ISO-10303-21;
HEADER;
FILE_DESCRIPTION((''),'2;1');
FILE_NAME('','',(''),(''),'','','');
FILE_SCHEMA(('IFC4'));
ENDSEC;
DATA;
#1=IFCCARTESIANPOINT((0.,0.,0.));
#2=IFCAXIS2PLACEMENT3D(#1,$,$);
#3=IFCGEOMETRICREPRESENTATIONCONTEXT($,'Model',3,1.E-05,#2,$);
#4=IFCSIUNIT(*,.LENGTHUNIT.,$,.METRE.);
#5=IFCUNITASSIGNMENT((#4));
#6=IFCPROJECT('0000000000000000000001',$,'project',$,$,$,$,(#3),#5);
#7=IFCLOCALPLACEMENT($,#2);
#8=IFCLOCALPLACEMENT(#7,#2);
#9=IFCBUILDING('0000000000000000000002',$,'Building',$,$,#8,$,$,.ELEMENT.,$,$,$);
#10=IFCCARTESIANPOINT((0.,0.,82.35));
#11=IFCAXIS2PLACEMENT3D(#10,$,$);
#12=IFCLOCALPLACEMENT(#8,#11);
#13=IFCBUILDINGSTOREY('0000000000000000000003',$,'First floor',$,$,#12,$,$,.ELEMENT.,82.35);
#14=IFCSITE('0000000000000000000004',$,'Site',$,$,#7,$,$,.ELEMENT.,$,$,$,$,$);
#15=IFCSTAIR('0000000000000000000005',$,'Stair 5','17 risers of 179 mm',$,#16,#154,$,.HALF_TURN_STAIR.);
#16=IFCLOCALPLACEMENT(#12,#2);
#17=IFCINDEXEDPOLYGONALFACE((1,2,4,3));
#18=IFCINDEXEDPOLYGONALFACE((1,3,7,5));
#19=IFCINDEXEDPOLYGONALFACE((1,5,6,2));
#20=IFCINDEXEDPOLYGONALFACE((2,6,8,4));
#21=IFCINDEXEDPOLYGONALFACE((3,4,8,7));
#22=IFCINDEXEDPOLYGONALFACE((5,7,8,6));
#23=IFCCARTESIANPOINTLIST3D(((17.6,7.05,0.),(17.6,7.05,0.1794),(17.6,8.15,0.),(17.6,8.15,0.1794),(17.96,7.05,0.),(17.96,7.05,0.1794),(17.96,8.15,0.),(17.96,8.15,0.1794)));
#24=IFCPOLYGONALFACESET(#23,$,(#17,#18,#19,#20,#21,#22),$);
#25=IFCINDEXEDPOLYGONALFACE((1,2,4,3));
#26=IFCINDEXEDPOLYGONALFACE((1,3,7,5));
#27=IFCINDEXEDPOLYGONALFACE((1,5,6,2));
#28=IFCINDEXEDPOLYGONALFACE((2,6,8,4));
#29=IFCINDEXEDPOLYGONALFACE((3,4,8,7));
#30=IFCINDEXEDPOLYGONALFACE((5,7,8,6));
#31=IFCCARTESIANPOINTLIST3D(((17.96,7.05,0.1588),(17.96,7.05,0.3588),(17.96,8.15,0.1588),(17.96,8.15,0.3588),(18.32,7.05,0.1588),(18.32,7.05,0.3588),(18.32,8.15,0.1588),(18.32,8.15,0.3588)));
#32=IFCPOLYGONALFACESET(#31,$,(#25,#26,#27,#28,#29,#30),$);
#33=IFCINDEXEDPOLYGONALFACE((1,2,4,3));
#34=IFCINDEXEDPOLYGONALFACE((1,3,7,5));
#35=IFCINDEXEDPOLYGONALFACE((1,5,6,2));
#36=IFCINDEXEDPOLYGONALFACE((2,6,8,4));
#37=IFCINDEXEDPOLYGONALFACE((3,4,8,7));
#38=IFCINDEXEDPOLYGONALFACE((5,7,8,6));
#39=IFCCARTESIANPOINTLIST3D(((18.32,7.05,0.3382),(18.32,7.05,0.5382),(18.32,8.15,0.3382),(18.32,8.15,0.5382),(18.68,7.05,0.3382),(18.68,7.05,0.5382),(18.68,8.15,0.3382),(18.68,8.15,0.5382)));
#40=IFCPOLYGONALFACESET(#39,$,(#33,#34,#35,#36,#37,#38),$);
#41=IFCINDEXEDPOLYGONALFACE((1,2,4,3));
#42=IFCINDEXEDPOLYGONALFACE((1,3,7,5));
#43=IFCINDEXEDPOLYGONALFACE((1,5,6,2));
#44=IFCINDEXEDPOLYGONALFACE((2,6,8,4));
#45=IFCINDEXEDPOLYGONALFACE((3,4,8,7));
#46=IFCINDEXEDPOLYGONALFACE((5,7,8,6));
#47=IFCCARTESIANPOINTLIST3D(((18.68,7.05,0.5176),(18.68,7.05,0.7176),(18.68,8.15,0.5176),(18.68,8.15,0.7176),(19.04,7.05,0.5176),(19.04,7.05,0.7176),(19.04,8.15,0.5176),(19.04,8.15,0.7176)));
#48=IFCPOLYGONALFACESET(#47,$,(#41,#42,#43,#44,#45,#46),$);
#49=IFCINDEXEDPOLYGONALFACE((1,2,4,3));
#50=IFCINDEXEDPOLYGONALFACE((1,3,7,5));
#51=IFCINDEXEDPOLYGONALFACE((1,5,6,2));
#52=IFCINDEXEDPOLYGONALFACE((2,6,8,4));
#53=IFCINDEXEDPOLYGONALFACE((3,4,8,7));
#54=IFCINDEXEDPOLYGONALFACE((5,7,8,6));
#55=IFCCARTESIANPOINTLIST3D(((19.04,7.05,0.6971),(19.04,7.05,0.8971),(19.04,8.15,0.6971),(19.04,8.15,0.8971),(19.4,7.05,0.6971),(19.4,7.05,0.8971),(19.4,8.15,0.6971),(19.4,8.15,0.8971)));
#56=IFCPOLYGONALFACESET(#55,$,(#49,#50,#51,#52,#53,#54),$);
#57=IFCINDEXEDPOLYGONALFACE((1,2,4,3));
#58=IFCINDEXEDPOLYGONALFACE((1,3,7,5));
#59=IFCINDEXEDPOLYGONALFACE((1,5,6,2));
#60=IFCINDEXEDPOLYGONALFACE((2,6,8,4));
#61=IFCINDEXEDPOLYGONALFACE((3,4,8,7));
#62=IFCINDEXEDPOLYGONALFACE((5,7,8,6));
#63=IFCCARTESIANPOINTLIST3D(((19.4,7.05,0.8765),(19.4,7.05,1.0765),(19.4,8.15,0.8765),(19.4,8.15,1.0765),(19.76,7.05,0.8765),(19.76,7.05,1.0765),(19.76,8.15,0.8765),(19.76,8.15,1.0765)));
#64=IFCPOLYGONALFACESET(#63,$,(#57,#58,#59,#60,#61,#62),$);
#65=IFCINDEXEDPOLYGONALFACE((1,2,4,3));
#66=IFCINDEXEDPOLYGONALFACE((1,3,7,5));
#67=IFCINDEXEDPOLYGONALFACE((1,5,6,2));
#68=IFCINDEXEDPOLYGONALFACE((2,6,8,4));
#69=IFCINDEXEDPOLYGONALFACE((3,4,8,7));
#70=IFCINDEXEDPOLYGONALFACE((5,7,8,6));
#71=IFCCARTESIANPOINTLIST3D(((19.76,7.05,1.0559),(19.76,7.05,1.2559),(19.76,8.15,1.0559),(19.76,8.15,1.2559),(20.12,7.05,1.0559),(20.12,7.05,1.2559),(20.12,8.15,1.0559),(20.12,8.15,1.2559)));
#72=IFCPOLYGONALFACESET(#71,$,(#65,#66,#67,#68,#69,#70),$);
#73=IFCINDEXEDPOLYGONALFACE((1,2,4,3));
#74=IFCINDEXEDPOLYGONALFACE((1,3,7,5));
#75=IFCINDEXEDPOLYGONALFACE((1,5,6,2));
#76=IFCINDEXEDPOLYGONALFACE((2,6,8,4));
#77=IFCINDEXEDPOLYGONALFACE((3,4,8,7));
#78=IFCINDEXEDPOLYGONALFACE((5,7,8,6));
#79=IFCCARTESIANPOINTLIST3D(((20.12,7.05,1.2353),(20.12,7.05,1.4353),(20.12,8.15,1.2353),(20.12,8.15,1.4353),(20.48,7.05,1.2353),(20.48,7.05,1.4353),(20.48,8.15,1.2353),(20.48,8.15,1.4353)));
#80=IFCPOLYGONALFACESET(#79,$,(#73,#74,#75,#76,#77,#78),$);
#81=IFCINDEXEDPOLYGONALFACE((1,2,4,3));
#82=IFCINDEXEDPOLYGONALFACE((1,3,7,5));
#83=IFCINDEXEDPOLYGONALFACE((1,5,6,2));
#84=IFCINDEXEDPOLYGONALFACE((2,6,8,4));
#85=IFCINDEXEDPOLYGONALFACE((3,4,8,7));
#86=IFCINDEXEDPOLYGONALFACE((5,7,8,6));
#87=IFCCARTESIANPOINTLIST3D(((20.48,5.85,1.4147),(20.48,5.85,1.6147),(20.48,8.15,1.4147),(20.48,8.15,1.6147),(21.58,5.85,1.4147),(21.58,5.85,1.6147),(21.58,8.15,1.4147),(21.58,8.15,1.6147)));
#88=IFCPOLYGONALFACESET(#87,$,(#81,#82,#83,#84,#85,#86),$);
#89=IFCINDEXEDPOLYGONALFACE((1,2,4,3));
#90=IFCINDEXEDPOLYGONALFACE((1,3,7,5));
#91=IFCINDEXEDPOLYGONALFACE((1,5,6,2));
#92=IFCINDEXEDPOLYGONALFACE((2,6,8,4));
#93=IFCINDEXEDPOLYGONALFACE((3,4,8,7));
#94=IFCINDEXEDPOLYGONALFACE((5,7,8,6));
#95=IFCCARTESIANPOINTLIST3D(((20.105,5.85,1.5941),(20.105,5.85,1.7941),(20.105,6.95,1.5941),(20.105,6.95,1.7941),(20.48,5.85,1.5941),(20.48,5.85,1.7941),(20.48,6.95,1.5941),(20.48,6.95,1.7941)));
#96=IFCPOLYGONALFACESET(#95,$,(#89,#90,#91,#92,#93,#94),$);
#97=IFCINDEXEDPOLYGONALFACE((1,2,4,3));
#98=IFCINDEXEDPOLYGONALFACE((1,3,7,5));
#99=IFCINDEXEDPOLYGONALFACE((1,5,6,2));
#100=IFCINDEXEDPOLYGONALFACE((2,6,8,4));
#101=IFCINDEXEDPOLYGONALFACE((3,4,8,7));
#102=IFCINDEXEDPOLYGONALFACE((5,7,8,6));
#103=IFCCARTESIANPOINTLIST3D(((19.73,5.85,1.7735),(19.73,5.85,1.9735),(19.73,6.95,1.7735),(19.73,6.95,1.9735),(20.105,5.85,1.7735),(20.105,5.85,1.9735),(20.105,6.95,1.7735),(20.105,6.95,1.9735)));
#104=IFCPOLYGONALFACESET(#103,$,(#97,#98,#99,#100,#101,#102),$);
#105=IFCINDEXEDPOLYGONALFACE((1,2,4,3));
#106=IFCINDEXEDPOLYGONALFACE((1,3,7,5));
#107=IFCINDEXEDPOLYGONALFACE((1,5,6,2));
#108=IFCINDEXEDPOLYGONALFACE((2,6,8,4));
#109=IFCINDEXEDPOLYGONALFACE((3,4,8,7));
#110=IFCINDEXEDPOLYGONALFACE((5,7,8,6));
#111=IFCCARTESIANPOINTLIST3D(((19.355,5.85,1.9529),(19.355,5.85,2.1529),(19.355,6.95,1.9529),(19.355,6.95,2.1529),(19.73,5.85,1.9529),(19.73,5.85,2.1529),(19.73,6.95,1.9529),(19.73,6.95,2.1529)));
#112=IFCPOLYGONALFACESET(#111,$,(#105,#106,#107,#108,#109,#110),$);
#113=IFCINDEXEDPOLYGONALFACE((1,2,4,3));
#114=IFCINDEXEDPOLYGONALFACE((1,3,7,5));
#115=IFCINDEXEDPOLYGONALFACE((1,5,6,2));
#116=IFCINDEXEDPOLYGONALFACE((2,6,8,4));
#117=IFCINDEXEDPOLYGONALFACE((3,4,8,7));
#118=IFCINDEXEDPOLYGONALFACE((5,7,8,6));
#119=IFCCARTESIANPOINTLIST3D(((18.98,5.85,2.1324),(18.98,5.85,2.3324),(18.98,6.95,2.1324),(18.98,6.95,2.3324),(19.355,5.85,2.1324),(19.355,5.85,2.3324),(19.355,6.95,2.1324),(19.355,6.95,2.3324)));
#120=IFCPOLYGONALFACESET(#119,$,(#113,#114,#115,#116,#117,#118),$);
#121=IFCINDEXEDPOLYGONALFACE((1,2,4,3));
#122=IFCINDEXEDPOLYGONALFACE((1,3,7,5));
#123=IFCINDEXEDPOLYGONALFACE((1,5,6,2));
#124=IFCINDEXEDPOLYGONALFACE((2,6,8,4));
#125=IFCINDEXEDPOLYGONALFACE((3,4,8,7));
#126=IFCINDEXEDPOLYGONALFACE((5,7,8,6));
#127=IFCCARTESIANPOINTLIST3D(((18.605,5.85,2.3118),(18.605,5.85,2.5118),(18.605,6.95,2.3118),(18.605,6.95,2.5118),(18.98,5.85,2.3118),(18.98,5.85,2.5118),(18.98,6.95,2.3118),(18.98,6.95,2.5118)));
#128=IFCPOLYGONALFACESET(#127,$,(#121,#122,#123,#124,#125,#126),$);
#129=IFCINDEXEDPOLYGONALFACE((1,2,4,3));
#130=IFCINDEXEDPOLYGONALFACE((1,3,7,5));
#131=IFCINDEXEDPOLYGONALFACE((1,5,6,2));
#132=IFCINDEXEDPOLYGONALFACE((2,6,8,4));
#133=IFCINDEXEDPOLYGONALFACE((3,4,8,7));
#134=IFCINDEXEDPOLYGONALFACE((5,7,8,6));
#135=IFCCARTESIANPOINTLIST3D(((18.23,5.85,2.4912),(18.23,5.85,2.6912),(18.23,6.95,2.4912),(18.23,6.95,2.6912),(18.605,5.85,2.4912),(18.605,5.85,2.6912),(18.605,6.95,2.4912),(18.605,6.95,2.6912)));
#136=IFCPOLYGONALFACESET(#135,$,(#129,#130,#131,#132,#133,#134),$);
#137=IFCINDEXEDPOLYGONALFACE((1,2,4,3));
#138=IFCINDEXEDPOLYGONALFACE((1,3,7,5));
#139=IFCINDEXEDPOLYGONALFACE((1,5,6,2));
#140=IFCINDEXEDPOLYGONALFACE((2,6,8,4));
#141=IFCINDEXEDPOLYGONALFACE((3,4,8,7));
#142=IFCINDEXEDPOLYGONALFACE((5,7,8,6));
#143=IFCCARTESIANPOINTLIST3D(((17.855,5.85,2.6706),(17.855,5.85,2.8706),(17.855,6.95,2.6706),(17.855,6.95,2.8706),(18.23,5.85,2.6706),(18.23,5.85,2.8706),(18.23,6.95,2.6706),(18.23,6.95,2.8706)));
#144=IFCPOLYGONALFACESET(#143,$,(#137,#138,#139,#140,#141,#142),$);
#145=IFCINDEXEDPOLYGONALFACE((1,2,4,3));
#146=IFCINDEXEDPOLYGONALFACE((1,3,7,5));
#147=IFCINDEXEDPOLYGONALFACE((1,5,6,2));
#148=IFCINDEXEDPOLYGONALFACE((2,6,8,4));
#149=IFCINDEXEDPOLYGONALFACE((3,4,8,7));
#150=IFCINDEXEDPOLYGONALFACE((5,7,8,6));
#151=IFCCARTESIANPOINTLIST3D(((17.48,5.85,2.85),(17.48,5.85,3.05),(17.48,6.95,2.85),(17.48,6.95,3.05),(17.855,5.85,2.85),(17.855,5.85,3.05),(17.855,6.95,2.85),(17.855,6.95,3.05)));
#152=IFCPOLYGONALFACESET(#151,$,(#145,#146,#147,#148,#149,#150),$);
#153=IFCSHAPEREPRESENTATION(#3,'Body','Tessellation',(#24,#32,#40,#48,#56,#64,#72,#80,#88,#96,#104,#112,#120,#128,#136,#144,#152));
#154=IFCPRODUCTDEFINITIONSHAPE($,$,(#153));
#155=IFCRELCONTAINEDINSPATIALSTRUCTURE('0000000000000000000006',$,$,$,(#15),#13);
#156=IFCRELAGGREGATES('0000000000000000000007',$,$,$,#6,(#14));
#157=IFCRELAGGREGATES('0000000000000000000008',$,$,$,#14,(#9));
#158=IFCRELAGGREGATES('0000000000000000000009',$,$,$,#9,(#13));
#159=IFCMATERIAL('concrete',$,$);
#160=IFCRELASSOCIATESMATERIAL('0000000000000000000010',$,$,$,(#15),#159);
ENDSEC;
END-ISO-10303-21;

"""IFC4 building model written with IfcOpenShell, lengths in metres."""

from ifc_helpers import new_model, si_unit, frame, origin, place, context, project, spatial, polyline, outline, extrude, material, element, save


model = new_model("IFC4")

# Units and contexts
model_context = context("Model", 3, precision=1e-05, world=origin())
ifc_project = project(units=[si_unit("LENGTHUNIT", "METRE")], contexts=[model_context])

# Site, building, storey
site_placement = place(None, origin())
site = spatial("IfcSite", under=ifc_project, at=site_placement, Name="Site", CompositionType="ELEMENT")
building_placement = place(site_placement, origin())
building = spatial("IfcBuilding", under=site, at=building_placement, Name="Building", CompositionType="ELEMENT")
storey_placement = place(building_placement, frame((0.0, 0.0, 82.35)))
storey = spatial("IfcBuildingStorey", under=building, at=storey_placement, Name="First floor", CompositionType="ELEMENT", Elevation=82.35)

# Shared definitions
ifc_material = material(Name="concrete")

# Stair
stair_1_placement = place(storey_placement, frame((17.6, 7.6, 0.0), z_axis=(0.0, 0.0, 1.0), x_axis=(1.0, 0.0, 0.0)))
element("IfcStair", 1, at=stair_1_placement, inside=storey, material=ifc_material, Name="Stair 5", Description="17 risers of 179 mm", PredefinedType="HALF_TURN_STAIR", context=model_context, shape_type="SweptSolid", body=[
    extrude(outline(polyline([(0.0, -0.55), (0.36, -0.55), (0.36, 0.55), (0.0, 0.55), (0.0, -0.55)])), origin(), (0.0, 0.0, 1.0), 0.1794),
    extrude(outline(polyline([(0.36, -0.55), (0.72, -0.55), (0.72, 0.55), (0.36, 0.55), (0.36, -0.55)])), frame((0.0, 0.0, 0.1588)), (0.0, 0.0, 1.0), 0.2),
    extrude(outline(polyline([(0.72, -0.55), (1.08, -0.55), (1.08, 0.55), (0.72, 0.55), (0.72, -0.55)])), frame((0.0, 0.0, 0.3382)), (0.0, 0.0, 1.0), 0.2),
    extrude(outline(polyline([(1.08, -0.55), (1.44, -0.55), (1.44, 0.55), (1.08, 0.55), (1.08, -0.55)])), frame((0.0, 0.0, 0.5176)), (0.0, 0.0, 1.0), 0.2),
    extrude(outline(polyline([(1.44, -0.55), (1.8, -0.55), (1.8, 0.55), (1.44, 0.55), (1.44, -0.55)])), frame((0.0, 0.0, 0.6971)), (0.0, 0.0, 1.0), 0.2),
    extrude(outline(polyline([(1.8, -0.55), (2.16, -0.55), (2.16, 0.55), (1.8, 0.55), (1.8, -0.55)])), frame((0.0, 0.0, 0.8765)), (0.0, 0.0, 1.0), 0.2),
    extrude(outline(polyline([(2.16, -0.55), (2.52, -0.55), (2.52, 0.55), (2.16, 0.55), (2.16, -0.55)])), frame((0.0, 0.0, 1.0559)), (0.0, 0.0, 1.0), 0.2),
    extrude(outline(polyline([(2.52, -0.55), (2.88, -0.55), (2.88, 0.55), (2.52, 0.55), (2.52, -0.55)])), frame((0.0, 0.0, 1.2353)), (0.0, 0.0, 1.0), 0.2),
    extrude(outline(polyline([(2.88, -1.75), (3.98, -1.75), (3.98, 0.55), (2.88, 0.55), (2.88, -1.75)])), frame((0.0, 0.0, 1.4147)), (0.0, 0.0, 1.0), 0.2),
    extrude(outline(polyline([(2.505, -1.75), (2.88, -1.75), (2.88, -0.65), (2.505, -0.65), (2.505, -1.75)])), frame((0.0, 0.0, 1.5941)), (0.0, 0.0, 1.0), 0.2),
    extrude(outline(polyline([(2.13, -1.75), (2.505, -1.75), (2.505, -0.65), (2.13, -0.65), (2.13, -1.75)])), frame((0.0, 0.0, 1.7735)), (0.0, 0.0, 1.0), 0.2),
    extrude(outline(polyline([(1.755, -1.75), (2.13, -1.75), (2.13, -0.65), (1.755, -0.65), (1.755, -1.75)])), frame((0.0, 0.0, 1.9529)), (0.0, 0.0, 1.0), 0.2),
    extrude(outline(polyline([(1.38, -1.75), (1.755, -1.75), (1.755, -0.65), (1.38, -0.65), (1.38, -1.75)])), frame((0.0, 0.0, 2.1324)), (0.0, 0.0, 1.0), 0.2),
    extrude(outline(polyline([(1.005, -1.75), (1.38, -1.75), (1.38, -0.65), (1.005, -0.65), (1.005, -1.75)])), frame((0.0, 0.0, 2.3118)), (0.0, 0.0, 1.0), 0.2),
    extrude(outline(polyline([(0.63, -1.75), (1.005, -1.75), (1.005, -0.65), (0.63, -0.65), (0.63, -1.75)])), frame((0.0, 0.0, 2.4912)), (0.0, 0.0, 1.0), 0.2),
    extrude(outline(polyline([(0.255, -1.75), (0.63, -1.75), (0.63, -0.65), (0.255, -0.65), (0.255, -1.75)])), frame((0.0, 0.0, 2.6706)), (0.0, 0.0, 1.0), 0.2),
    extrude(outline(polyline([(-0.12, -1.75), (0.255, -1.75), (0.255, -0.65), (-0.12, -0.65), (-0.12, -1.75)])), frame((0.0, 0.0, 2.85)), (0.0, 0.0, 1.0), 0.2),
])

save(model, "model.ifc")
